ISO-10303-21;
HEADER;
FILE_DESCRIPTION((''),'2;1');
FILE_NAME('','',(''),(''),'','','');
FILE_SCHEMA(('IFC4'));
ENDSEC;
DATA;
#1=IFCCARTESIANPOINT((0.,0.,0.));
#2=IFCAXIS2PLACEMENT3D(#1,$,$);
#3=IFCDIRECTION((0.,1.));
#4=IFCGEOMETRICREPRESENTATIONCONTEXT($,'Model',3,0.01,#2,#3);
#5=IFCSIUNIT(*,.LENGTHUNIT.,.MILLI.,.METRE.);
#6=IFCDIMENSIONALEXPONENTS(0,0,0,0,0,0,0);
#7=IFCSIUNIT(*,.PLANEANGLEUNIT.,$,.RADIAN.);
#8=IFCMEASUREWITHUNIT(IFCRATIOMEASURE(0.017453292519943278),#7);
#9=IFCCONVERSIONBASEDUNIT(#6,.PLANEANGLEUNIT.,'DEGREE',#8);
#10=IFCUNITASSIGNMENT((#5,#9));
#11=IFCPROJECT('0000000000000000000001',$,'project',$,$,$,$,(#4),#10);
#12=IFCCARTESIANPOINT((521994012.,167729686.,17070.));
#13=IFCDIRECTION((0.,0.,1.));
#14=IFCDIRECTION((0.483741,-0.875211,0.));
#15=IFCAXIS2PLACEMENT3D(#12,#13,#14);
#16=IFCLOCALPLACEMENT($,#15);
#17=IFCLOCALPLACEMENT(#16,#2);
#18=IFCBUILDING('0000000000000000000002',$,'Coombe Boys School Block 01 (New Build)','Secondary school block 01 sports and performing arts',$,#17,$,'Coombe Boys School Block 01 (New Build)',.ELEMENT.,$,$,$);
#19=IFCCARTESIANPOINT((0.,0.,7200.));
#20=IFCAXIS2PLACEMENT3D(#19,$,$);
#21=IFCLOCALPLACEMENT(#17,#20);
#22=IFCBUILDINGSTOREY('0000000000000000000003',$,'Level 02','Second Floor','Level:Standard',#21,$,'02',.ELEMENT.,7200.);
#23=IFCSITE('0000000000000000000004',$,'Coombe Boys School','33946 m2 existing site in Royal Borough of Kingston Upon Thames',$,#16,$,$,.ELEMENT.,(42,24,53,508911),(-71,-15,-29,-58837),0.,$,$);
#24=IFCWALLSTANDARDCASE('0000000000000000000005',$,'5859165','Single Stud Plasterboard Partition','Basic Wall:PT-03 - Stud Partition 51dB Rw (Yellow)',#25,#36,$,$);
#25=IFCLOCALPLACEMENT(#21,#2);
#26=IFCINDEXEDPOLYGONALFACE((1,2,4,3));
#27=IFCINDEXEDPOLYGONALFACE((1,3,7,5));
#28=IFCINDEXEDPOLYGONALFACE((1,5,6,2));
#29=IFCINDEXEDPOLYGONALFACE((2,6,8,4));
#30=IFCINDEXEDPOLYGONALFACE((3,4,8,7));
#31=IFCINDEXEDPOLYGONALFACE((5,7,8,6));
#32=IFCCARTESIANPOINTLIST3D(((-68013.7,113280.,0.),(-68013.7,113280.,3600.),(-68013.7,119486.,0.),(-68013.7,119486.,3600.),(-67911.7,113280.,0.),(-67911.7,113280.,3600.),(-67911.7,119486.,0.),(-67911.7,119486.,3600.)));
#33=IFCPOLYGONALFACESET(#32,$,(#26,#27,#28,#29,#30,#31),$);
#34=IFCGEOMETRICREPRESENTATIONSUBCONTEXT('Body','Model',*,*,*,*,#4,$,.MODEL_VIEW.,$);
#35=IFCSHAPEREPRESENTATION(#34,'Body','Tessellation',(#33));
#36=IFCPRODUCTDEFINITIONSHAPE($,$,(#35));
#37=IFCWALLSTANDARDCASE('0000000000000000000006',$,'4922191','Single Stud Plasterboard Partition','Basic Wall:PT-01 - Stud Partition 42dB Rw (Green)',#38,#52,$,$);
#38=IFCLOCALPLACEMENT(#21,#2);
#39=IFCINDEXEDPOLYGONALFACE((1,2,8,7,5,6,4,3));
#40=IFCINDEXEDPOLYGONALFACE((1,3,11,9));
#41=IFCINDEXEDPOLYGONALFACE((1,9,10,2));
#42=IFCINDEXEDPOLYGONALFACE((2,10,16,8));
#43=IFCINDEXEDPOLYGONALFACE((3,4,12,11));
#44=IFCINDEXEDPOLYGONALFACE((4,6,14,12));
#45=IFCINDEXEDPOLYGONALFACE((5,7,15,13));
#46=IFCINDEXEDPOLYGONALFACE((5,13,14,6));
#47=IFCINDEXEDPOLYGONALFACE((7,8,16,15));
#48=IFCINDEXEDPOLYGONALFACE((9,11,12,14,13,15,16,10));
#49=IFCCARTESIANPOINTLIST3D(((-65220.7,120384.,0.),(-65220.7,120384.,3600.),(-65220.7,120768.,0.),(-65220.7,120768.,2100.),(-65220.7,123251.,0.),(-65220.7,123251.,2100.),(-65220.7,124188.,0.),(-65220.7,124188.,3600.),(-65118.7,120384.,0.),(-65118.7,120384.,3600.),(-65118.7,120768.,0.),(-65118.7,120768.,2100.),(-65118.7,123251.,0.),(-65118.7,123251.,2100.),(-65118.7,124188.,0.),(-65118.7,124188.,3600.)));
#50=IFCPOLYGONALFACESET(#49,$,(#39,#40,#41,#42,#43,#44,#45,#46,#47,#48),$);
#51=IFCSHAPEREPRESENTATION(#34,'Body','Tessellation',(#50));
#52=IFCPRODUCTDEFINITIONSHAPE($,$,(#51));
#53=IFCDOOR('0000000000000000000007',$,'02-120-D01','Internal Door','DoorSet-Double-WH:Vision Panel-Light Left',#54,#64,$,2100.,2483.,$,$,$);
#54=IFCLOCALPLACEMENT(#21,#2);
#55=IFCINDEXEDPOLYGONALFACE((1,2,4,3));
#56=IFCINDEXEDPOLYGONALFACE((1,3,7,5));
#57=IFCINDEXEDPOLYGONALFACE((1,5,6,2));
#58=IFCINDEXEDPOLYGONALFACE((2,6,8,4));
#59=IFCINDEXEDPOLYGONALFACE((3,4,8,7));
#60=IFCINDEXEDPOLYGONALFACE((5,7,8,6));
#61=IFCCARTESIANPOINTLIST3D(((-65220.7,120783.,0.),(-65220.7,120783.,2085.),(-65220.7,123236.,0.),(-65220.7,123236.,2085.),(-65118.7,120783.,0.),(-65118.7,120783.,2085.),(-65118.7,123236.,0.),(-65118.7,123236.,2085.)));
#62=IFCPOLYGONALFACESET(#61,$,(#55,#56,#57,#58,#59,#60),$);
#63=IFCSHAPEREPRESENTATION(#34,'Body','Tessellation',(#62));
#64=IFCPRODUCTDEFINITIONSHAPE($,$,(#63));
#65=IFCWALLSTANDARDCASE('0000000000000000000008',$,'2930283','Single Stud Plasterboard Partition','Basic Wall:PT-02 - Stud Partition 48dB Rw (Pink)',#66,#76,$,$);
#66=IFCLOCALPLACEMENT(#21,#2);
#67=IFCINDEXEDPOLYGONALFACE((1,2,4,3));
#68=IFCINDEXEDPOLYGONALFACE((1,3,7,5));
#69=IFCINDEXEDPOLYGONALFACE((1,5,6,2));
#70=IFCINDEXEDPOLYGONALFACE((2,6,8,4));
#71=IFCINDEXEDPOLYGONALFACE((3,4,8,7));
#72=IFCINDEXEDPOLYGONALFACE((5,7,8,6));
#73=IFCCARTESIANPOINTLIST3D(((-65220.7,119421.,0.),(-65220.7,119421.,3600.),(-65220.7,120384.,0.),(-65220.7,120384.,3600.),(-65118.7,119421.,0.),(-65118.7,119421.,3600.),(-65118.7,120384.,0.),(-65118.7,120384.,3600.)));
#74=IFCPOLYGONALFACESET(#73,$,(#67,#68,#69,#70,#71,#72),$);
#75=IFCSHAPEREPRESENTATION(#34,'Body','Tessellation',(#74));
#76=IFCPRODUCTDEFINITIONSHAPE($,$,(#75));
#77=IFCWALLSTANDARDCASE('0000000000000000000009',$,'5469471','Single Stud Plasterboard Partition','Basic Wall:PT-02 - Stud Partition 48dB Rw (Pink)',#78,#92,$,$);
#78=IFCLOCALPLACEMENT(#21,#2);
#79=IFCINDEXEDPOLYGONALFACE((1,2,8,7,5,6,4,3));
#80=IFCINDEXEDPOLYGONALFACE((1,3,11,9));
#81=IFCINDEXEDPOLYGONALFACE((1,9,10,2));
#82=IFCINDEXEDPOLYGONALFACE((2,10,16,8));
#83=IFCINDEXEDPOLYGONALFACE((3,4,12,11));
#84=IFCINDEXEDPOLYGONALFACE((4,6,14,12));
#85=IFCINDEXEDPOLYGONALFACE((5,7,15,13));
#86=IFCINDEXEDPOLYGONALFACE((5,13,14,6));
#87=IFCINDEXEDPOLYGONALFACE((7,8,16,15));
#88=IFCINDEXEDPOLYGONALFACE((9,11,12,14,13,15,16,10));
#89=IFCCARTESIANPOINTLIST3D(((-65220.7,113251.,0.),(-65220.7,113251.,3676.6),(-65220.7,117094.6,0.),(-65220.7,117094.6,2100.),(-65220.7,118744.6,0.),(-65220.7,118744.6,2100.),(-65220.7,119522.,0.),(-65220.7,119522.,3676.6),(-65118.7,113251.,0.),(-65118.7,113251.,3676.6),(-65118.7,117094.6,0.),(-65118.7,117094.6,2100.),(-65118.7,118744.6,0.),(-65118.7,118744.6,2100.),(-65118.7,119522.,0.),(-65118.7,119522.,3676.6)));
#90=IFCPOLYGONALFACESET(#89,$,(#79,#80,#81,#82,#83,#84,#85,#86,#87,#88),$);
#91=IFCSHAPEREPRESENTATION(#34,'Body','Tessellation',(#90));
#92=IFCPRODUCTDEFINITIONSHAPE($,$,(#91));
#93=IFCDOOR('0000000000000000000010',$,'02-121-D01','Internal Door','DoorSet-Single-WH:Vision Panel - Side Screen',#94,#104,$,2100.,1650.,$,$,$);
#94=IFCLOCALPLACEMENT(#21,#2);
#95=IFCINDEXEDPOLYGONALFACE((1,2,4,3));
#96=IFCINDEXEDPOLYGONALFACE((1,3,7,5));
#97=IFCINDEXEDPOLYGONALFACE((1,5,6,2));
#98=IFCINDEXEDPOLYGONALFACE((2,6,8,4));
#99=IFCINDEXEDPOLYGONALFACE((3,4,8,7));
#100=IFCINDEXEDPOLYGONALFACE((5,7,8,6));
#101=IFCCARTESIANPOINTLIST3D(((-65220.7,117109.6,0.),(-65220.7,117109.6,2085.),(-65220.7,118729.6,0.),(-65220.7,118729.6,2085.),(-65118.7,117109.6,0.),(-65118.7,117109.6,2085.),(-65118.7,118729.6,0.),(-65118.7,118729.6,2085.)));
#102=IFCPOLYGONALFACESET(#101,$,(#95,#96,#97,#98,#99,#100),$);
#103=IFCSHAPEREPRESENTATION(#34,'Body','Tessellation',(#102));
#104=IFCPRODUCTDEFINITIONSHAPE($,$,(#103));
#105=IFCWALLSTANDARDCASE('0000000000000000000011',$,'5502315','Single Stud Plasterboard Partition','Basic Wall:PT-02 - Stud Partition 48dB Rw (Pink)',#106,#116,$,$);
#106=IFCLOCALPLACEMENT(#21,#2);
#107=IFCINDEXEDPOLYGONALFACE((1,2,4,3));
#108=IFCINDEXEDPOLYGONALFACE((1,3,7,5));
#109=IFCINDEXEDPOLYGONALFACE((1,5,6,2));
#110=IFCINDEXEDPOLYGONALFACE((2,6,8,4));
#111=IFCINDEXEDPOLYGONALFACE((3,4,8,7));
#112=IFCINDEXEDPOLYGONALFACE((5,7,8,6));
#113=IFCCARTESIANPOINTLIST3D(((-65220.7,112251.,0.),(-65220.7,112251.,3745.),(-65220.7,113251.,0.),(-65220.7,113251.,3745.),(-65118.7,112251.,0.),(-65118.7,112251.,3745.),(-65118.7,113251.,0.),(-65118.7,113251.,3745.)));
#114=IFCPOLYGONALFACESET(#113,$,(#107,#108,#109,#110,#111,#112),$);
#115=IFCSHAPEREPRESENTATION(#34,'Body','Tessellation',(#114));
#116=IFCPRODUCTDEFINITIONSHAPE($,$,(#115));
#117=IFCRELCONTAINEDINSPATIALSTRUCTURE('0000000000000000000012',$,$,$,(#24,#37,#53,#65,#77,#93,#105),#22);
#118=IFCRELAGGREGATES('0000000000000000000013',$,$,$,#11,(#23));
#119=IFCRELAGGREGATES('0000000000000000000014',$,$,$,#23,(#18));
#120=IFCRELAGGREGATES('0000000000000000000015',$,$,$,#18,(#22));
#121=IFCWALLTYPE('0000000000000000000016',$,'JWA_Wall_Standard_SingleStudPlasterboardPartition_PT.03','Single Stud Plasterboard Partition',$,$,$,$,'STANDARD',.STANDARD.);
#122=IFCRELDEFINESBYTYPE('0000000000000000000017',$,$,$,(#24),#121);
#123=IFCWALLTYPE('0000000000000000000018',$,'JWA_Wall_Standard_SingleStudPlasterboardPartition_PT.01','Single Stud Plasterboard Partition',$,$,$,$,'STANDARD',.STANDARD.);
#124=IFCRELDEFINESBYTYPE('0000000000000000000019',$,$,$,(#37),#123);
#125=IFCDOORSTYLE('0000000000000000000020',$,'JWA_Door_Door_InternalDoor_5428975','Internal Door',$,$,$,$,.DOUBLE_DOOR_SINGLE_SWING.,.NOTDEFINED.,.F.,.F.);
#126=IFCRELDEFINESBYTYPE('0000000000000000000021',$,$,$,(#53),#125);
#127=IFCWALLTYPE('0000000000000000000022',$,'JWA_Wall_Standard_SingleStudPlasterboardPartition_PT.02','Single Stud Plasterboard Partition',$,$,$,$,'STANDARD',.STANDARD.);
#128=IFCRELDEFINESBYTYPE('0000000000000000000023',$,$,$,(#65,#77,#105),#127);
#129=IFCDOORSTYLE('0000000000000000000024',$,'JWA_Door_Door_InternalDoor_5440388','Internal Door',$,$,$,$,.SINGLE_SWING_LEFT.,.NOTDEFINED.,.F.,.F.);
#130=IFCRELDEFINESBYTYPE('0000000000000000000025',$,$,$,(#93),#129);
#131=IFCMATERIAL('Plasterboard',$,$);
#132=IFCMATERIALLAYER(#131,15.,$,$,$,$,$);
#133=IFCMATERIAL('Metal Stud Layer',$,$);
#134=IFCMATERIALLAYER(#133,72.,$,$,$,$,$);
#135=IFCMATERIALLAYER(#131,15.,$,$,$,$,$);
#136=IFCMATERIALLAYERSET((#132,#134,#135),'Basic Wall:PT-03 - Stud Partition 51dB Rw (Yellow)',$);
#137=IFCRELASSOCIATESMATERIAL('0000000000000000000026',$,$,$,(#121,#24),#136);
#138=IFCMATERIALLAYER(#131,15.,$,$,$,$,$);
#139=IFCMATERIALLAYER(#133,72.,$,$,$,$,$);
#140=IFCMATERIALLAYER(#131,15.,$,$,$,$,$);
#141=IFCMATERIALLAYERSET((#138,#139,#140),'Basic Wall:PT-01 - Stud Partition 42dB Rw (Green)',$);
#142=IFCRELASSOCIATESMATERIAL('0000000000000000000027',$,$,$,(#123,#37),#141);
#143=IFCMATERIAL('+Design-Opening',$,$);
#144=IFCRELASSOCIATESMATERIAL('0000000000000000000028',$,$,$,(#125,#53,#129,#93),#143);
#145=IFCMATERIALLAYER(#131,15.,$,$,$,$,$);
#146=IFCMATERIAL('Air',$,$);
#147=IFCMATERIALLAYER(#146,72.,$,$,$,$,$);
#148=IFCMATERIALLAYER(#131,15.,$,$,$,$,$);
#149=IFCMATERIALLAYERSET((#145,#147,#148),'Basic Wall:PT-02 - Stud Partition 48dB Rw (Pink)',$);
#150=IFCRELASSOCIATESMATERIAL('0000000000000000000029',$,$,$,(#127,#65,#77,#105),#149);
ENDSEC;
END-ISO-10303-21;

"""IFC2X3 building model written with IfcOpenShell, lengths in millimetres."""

from ifc_helpers import new_model, entity, si_unit, converted_unit, direction, frame, frame_2d, origin, origin_2d_with_axis, place, context, subcontext, project, spatial, rectangle, extrude, source, transform, mapped, material, layer, layer_set, layer_usage, type_object, type_shapes, element, fill, save


model = new_model("IFC2X3")

# Units and contexts
model_context = context("Model", 3, precision=0.01, world=origin(), true_north=direction((0.0, 1.0)))
body_context = subcontext(model_context, "Body", "Model", "MODEL_VIEW")
ifc_project = project(units=[si_unit("LENGTHUNIT", "METRE", prefix="MILLI"), converted_unit("PLANEANGLEUNIT", "DEGREE", entity("IfcRatioMeasure", 0.017453292519943278), si_unit("PLANEANGLEUNIT", "RADIAN"), dimensions=[0, 0, 0, 0, 0, 0, 0])], contexts=[model_context])

# Site, building, storey
site_placement = place(None, frame((521994012.0, 167729686.0, 17070.0), z_axis=(0.0, 0.0, 1.0), x_axis=(0.483741, -0.875211, 0.0)))
site = spatial("IfcSite", under=ifc_project, at=site_placement, Name="Coombe Boys School", Description="33946 m2 existing site in Royal Borough of Kingston Upon Thames", CompositionType="ELEMENT", RefLatitude=(42, 24, 53, 508911), RefLongitude=(-71, -15, -29, -58837), RefElevation=0.0)
building_placement = place(site_placement, origin())
building = spatial("IfcBuilding", under=site, at=building_placement, Name="Coombe Boys School Block 01 (New Build)", Description="Secondary school block 01 sports and performing arts", LongName="Coombe Boys School Block 01 (New Build)", CompositionType="ELEMENT")
storey_placement = place(building_placement, frame((0.0, 0.0, 7200.0)))
storey = spatial("IfcBuildingStorey", under=building, at=storey_placement, Name="Level 02", Description="Second Floor", ObjectType="Level:Standard", LongName="02", CompositionType="ELEMENT", Elevation=7200.0)

# Wall
ifc_material_1 = material(Name="Plasterboard")
ifc_layer_1 = layer(ifc_material_1, 15.0)
ifc_material_2 = material(Name="Metal Stud Layer")
ifc_layer_2 = layer(ifc_material_2, 72.0)
ifc_layer_3 = layer(ifc_material_1, 15.0)
ifc_layer_set_1 = layer_set([ifc_layer_1, ifc_layer_2, ifc_layer_3], Name="Basic Wall:PT-03 - Stud Partition 51dB Rw (Yellow)")
ifc_layer_usage_1 = layer_usage(ifc_layer_set_1, "AXIS2", "POSITIVE", -51.0)
wall_type_1 = type_object("IfcWallType", Name="JWA_Wall_Standard_SingleStudPlasterboardPartition_PT.03", Description="Single Stud Plasterboard Partition", ElementType="STANDARD", PredefinedType="STANDARD", material=ifc_layer_set_1)
wall_1_placement = place(storey_placement, frame((-67962.7, 119486.0, 0.0), z_axis=(0.0, 0.0, 1.0), x_axis=(0.0, -1.0, 0.0)))
element("IfcWallStandardCase", 1, at=wall_1_placement, inside=storey, type_object=wall_type_1, material=ifc_layer_usage_1, Name="5859165", Description="Single Stud Plasterboard Partition", ObjectType="Basic Wall:PT-03 - Stud Partition 51dB Rw (Yellow)", context=body_context, shape_type="SweptSolid", body=[
    extrude(rectangle(XDim=6206.0, YDim=102.0, at=frame_2d((3103.0, 0.0), x_axis=(-1.0, 0.0))), origin(), (0.0, 0.0, 1.0), 3600.0),
])

# Wall, opening, door
ifc_layer_4 = layer(ifc_material_1, 15.0)
ifc_layer_5 = layer(ifc_material_2, 72.0)
ifc_layer_6 = layer(ifc_material_1, 15.0)
ifc_layer_set_2 = layer_set([ifc_layer_4, ifc_layer_5, ifc_layer_6], Name="Basic Wall:PT-01 - Stud Partition 42dB Rw (Green)")
ifc_layer_usage_2 = layer_usage(ifc_layer_set_2, "AXIS2", "NEGATIVE", 51.0)
wall_type_2 = type_object("IfcWallType", Name="JWA_Wall_Standard_SingleStudPlasterboardPartition_PT.01", Description="Single Stud Plasterboard Partition", ElementType="STANDARD", PredefinedType="STANDARD", material=ifc_layer_set_2)
ifc_material_3 = material(Name="+Design-Opening")
wall_2_placement = place(storey_placement, frame((-65169.7, 124188.0, 0.0), z_axis=(0.0, 0.0, 1.0), x_axis=(0.0, -1.0, 0.0)))
wall_2 = element("IfcWallStandardCase", 2, at=wall_2_placement, inside=storey, type_object=wall_type_2, material=ifc_layer_usage_2, Name="4922191", Description="Single Stud Plasterboard Partition", ObjectType="Basic Wall:PT-01 - Stud Partition 42dB Rw (Green)", context=body_context, shape_type="SweptSolid", body=[
    extrude(rectangle(XDim=3804.0, YDim=102.0, at=frame_2d((1902.0, 0.0), x_axis=(1.0, 0.0))), origin(), (0.0, 0.0, 1.0), 3600.0),
])
opening_1_placement = place(wall_2_placement, frame((124188.0, 65169.7, 0.0), z_axis=(0.0, 0.0, 1.0), x_axis=(0.0, 1.0, 0.0)))
opening_1 = element("IfcOpeningElement", 3, at=opening_1_placement, cuts=wall_2, ObjectType="Opening", context=body_context, shape_type="SweptSolid", body=[
    extrude(rectangle(XDim=2100.0, YDim=2483.0, at=frame_2d((0.0, 0.0), x_axis=(1.0, 0.0))), frame((-65220.7, 122009.5, 1050.0), z_axis=(1.0, 0.0, 0.0), x_axis=(0.0, 0.0, -1.0)), (0.0, 0.0, 1.0), 102.0),
])
door_style_1 = type_object("IfcDoorStyle", Name="JWA_Door_Door_InternalDoor_5428975", Description="Internal Door", ConstructionType="NOTDEFINED", OperationType="DOUBLE_DOOR_SINGLE_SWING", ParameterTakesPrecedence=False, Sizeable=False, material=ifc_material_3)
shared_shape_1 = source(origin(), body_context, "Body", "SweptSolid", [
    extrude(rectangle(XDim=102.0, YDim=2453.0, at=frame_2d((0.0, 0.0), x_axis=(1.0, 0.0))), frame((-160.0, 0.0, 0.0), z_axis=(0.0, 0.0, 1.0), x_axis=(0.0, 1.0, 0.0)), (0.0, 0.0, 1.0), 2085.0),
])
type_shapes(door_style_1, [shared_shape_1])
door_1_placement = place(opening_1_placement, frame((-65169.7, 121849.5, 0.0), z_axis=(0.0, 0.0, 1.0), x_axis=(0.0, -1.0, 0.0)))
door_1 = element("IfcDoor", 4, at=door_1_placement, inside=storey, type_object=door_style_1, material=ifc_material_3, Name="02-120-D01", Description="Internal Door", ObjectType="DoorSet-Double-WH:Vision Panel-Light Left", OverallHeight=2100.0, OverallWidth=2483.0, context=body_context, shape_type="MappedRepresentation", body=[
    mapped(shared_shape_1, transform((0.0, 0.0, 0.0), scale=1.0)),
])
fill(opening_1, door_1)

# Wall
ifc_layer_7 = layer(ifc_material_1, 15.0)
ifc_material_4 = material(Name="Air")
ifc_layer_8 = layer(ifc_material_4, 72.0)
ifc_layer_9 = layer(ifc_material_1, 15.0)
ifc_layer_set_3 = layer_set([ifc_layer_7, ifc_layer_8, ifc_layer_9], Name="Basic Wall:PT-02 - Stud Partition 48dB Rw (Pink)")
ifc_layer_usage_3 = layer_usage(ifc_layer_set_3, "AXIS2", "NEGATIVE", 51.0)
wall_type_3 = type_object("IfcWallType", Name="JWA_Wall_Standard_SingleStudPlasterboardPartition_PT.02", Description="Single Stud Plasterboard Partition", ElementType="STANDARD", PredefinedType="STANDARD", material=ifc_layer_set_3)
wall_3_placement = place(storey_placement, frame((-65169.7, 120384.0, 0.0), z_axis=(0.0, 0.0, 1.0), x_axis=(0.0, -1.0, 0.0)))
element("IfcWallStandardCase", 5, at=wall_3_placement, inside=storey, type_object=wall_type_3, material=ifc_layer_usage_3, Name="2930283", Description="Single Stud Plasterboard Partition", ObjectType="Basic Wall:PT-02 - Stud Partition 48dB Rw (Pink)", context=body_context, shape_type="SweptSolid", body=[
    extrude(rectangle(XDim=963.0, YDim=102.0, at=frame_2d((481.5, 0.0), x_axis=(-1.0, 0.0))), origin(), (0.0, 0.0, 1.0), 3600.0),
])

# Wall, opening, door
wall_4_placement = place(storey_placement, frame((-65169.7, 119522.0, 0.0), z_axis=(0.0, 0.0, 1.0), x_axis=(0.0, -1.0, 0.0)))
wall_4 = element("IfcWallStandardCase", 6, at=wall_4_placement, inside=storey, type_object=wall_type_3, material=ifc_layer_usage_3, Name="5469471", Description="Single Stud Plasterboard Partition", ObjectType="Basic Wall:PT-02 - Stud Partition 48dB Rw (Pink)", context=body_context, shape_type="SweptSolid", body=[
    extrude(rectangle(XDim=6271.0, YDim=102.0, at=frame_2d((3135.5, 0.0), x_axis=(1.0, 0.0))), origin(), (0.0, 0.0, 1.0), 3676.6),
])
opening_2_placement = place(wall_4_placement, frame((119522.0, 65169.7, 0.0), z_axis=(0.0, 0.0, 1.0), x_axis=(0.0, 1.0, 0.0)))
opening_2 = element("IfcOpeningElement", 7, at=opening_2_placement, cuts=wall_4, ObjectType="Opening", context=body_context, shape_type="SweptSolid", body=[
    extrude(rectangle(XDim=2100.0, YDim=1650.0, at=frame_2d((0.0, 0.0), x_axis=(0.0, 1.0))), frame((-65220.7, 117919.6, 1050.0), z_axis=(1.0, 0.0, 0.0), x_axis=(0.0, -1.0, 0.0)), (0.0, 0.0, 1.0), 102.0),
])
door_style_2 = type_object("IfcDoorStyle", Name="JWA_Door_Door_InternalDoor_5440388", Description="Internal Door", ConstructionType="NOTDEFINED", OperationType="SINGLE_SWING_LEFT", ParameterTakesPrecedence=False, Sizeable=False, material=ifc_material_3)
shared_shape_2 = source(origin(), body_context, "Body", "SweptSolid", [
    extrude(rectangle(XDim=1620.0, YDim=102.0, at=origin_2d_with_axis()), frame((-160.0, 0.0, 0.0), z_axis=(0.0, 0.0, 1.0), x_axis=(-1.0, 0.0, 0.0)), (0.0, 0.0, 1.0), 2085.0),
])
type_shapes(door_style_2, [shared_shape_2])
door_2_placement = place(opening_2_placement, frame((-65169.7, 118079.6, 0.0), z_axis=(0.0, 0.0, 1.0), x_axis=(0.0, 1.0, 0.0)))
door_2 = element("IfcDoor", 8, at=door_2_placement, inside=storey, type_object=door_style_2, material=ifc_material_3, Name="02-121-D01", Description="Internal Door", ObjectType="DoorSet-Single-WH:Vision Panel - Side Screen", OverallHeight=2100.0, OverallWidth=1650.0, context=body_context, shape_type="MappedRepresentation", body=[
    mapped(shared_shape_2, transform((0.0, 0.0, 0.0), scale=1.0)),
])
fill(opening_2, door_2)

# Wall
wall_5_placement = place(storey_placement, frame((-65169.7, 113251.0, 0.0), z_axis=(0.0, 0.0, 1.0), x_axis=(0.0, -1.0, 0.0)))
element("IfcWallStandardCase", 9, at=wall_5_placement, inside=storey, type_object=wall_type_3, material=ifc_layer_usage_3, Name="5502315", Description="Single Stud Plasterboard Partition", ObjectType="Basic Wall:PT-02 - Stud Partition 48dB Rw (Pink)", context=body_context, shape_type="SweptSolid", body=[
    extrude(rectangle(XDim=1000.0, YDim=102.0, at=frame_2d((500.0, 0.0), x_axis=(-1.0, 0.0))), origin(), (0.0, 0.0, 1.0), 3745.0),
])

save(model, "model.ifc")
